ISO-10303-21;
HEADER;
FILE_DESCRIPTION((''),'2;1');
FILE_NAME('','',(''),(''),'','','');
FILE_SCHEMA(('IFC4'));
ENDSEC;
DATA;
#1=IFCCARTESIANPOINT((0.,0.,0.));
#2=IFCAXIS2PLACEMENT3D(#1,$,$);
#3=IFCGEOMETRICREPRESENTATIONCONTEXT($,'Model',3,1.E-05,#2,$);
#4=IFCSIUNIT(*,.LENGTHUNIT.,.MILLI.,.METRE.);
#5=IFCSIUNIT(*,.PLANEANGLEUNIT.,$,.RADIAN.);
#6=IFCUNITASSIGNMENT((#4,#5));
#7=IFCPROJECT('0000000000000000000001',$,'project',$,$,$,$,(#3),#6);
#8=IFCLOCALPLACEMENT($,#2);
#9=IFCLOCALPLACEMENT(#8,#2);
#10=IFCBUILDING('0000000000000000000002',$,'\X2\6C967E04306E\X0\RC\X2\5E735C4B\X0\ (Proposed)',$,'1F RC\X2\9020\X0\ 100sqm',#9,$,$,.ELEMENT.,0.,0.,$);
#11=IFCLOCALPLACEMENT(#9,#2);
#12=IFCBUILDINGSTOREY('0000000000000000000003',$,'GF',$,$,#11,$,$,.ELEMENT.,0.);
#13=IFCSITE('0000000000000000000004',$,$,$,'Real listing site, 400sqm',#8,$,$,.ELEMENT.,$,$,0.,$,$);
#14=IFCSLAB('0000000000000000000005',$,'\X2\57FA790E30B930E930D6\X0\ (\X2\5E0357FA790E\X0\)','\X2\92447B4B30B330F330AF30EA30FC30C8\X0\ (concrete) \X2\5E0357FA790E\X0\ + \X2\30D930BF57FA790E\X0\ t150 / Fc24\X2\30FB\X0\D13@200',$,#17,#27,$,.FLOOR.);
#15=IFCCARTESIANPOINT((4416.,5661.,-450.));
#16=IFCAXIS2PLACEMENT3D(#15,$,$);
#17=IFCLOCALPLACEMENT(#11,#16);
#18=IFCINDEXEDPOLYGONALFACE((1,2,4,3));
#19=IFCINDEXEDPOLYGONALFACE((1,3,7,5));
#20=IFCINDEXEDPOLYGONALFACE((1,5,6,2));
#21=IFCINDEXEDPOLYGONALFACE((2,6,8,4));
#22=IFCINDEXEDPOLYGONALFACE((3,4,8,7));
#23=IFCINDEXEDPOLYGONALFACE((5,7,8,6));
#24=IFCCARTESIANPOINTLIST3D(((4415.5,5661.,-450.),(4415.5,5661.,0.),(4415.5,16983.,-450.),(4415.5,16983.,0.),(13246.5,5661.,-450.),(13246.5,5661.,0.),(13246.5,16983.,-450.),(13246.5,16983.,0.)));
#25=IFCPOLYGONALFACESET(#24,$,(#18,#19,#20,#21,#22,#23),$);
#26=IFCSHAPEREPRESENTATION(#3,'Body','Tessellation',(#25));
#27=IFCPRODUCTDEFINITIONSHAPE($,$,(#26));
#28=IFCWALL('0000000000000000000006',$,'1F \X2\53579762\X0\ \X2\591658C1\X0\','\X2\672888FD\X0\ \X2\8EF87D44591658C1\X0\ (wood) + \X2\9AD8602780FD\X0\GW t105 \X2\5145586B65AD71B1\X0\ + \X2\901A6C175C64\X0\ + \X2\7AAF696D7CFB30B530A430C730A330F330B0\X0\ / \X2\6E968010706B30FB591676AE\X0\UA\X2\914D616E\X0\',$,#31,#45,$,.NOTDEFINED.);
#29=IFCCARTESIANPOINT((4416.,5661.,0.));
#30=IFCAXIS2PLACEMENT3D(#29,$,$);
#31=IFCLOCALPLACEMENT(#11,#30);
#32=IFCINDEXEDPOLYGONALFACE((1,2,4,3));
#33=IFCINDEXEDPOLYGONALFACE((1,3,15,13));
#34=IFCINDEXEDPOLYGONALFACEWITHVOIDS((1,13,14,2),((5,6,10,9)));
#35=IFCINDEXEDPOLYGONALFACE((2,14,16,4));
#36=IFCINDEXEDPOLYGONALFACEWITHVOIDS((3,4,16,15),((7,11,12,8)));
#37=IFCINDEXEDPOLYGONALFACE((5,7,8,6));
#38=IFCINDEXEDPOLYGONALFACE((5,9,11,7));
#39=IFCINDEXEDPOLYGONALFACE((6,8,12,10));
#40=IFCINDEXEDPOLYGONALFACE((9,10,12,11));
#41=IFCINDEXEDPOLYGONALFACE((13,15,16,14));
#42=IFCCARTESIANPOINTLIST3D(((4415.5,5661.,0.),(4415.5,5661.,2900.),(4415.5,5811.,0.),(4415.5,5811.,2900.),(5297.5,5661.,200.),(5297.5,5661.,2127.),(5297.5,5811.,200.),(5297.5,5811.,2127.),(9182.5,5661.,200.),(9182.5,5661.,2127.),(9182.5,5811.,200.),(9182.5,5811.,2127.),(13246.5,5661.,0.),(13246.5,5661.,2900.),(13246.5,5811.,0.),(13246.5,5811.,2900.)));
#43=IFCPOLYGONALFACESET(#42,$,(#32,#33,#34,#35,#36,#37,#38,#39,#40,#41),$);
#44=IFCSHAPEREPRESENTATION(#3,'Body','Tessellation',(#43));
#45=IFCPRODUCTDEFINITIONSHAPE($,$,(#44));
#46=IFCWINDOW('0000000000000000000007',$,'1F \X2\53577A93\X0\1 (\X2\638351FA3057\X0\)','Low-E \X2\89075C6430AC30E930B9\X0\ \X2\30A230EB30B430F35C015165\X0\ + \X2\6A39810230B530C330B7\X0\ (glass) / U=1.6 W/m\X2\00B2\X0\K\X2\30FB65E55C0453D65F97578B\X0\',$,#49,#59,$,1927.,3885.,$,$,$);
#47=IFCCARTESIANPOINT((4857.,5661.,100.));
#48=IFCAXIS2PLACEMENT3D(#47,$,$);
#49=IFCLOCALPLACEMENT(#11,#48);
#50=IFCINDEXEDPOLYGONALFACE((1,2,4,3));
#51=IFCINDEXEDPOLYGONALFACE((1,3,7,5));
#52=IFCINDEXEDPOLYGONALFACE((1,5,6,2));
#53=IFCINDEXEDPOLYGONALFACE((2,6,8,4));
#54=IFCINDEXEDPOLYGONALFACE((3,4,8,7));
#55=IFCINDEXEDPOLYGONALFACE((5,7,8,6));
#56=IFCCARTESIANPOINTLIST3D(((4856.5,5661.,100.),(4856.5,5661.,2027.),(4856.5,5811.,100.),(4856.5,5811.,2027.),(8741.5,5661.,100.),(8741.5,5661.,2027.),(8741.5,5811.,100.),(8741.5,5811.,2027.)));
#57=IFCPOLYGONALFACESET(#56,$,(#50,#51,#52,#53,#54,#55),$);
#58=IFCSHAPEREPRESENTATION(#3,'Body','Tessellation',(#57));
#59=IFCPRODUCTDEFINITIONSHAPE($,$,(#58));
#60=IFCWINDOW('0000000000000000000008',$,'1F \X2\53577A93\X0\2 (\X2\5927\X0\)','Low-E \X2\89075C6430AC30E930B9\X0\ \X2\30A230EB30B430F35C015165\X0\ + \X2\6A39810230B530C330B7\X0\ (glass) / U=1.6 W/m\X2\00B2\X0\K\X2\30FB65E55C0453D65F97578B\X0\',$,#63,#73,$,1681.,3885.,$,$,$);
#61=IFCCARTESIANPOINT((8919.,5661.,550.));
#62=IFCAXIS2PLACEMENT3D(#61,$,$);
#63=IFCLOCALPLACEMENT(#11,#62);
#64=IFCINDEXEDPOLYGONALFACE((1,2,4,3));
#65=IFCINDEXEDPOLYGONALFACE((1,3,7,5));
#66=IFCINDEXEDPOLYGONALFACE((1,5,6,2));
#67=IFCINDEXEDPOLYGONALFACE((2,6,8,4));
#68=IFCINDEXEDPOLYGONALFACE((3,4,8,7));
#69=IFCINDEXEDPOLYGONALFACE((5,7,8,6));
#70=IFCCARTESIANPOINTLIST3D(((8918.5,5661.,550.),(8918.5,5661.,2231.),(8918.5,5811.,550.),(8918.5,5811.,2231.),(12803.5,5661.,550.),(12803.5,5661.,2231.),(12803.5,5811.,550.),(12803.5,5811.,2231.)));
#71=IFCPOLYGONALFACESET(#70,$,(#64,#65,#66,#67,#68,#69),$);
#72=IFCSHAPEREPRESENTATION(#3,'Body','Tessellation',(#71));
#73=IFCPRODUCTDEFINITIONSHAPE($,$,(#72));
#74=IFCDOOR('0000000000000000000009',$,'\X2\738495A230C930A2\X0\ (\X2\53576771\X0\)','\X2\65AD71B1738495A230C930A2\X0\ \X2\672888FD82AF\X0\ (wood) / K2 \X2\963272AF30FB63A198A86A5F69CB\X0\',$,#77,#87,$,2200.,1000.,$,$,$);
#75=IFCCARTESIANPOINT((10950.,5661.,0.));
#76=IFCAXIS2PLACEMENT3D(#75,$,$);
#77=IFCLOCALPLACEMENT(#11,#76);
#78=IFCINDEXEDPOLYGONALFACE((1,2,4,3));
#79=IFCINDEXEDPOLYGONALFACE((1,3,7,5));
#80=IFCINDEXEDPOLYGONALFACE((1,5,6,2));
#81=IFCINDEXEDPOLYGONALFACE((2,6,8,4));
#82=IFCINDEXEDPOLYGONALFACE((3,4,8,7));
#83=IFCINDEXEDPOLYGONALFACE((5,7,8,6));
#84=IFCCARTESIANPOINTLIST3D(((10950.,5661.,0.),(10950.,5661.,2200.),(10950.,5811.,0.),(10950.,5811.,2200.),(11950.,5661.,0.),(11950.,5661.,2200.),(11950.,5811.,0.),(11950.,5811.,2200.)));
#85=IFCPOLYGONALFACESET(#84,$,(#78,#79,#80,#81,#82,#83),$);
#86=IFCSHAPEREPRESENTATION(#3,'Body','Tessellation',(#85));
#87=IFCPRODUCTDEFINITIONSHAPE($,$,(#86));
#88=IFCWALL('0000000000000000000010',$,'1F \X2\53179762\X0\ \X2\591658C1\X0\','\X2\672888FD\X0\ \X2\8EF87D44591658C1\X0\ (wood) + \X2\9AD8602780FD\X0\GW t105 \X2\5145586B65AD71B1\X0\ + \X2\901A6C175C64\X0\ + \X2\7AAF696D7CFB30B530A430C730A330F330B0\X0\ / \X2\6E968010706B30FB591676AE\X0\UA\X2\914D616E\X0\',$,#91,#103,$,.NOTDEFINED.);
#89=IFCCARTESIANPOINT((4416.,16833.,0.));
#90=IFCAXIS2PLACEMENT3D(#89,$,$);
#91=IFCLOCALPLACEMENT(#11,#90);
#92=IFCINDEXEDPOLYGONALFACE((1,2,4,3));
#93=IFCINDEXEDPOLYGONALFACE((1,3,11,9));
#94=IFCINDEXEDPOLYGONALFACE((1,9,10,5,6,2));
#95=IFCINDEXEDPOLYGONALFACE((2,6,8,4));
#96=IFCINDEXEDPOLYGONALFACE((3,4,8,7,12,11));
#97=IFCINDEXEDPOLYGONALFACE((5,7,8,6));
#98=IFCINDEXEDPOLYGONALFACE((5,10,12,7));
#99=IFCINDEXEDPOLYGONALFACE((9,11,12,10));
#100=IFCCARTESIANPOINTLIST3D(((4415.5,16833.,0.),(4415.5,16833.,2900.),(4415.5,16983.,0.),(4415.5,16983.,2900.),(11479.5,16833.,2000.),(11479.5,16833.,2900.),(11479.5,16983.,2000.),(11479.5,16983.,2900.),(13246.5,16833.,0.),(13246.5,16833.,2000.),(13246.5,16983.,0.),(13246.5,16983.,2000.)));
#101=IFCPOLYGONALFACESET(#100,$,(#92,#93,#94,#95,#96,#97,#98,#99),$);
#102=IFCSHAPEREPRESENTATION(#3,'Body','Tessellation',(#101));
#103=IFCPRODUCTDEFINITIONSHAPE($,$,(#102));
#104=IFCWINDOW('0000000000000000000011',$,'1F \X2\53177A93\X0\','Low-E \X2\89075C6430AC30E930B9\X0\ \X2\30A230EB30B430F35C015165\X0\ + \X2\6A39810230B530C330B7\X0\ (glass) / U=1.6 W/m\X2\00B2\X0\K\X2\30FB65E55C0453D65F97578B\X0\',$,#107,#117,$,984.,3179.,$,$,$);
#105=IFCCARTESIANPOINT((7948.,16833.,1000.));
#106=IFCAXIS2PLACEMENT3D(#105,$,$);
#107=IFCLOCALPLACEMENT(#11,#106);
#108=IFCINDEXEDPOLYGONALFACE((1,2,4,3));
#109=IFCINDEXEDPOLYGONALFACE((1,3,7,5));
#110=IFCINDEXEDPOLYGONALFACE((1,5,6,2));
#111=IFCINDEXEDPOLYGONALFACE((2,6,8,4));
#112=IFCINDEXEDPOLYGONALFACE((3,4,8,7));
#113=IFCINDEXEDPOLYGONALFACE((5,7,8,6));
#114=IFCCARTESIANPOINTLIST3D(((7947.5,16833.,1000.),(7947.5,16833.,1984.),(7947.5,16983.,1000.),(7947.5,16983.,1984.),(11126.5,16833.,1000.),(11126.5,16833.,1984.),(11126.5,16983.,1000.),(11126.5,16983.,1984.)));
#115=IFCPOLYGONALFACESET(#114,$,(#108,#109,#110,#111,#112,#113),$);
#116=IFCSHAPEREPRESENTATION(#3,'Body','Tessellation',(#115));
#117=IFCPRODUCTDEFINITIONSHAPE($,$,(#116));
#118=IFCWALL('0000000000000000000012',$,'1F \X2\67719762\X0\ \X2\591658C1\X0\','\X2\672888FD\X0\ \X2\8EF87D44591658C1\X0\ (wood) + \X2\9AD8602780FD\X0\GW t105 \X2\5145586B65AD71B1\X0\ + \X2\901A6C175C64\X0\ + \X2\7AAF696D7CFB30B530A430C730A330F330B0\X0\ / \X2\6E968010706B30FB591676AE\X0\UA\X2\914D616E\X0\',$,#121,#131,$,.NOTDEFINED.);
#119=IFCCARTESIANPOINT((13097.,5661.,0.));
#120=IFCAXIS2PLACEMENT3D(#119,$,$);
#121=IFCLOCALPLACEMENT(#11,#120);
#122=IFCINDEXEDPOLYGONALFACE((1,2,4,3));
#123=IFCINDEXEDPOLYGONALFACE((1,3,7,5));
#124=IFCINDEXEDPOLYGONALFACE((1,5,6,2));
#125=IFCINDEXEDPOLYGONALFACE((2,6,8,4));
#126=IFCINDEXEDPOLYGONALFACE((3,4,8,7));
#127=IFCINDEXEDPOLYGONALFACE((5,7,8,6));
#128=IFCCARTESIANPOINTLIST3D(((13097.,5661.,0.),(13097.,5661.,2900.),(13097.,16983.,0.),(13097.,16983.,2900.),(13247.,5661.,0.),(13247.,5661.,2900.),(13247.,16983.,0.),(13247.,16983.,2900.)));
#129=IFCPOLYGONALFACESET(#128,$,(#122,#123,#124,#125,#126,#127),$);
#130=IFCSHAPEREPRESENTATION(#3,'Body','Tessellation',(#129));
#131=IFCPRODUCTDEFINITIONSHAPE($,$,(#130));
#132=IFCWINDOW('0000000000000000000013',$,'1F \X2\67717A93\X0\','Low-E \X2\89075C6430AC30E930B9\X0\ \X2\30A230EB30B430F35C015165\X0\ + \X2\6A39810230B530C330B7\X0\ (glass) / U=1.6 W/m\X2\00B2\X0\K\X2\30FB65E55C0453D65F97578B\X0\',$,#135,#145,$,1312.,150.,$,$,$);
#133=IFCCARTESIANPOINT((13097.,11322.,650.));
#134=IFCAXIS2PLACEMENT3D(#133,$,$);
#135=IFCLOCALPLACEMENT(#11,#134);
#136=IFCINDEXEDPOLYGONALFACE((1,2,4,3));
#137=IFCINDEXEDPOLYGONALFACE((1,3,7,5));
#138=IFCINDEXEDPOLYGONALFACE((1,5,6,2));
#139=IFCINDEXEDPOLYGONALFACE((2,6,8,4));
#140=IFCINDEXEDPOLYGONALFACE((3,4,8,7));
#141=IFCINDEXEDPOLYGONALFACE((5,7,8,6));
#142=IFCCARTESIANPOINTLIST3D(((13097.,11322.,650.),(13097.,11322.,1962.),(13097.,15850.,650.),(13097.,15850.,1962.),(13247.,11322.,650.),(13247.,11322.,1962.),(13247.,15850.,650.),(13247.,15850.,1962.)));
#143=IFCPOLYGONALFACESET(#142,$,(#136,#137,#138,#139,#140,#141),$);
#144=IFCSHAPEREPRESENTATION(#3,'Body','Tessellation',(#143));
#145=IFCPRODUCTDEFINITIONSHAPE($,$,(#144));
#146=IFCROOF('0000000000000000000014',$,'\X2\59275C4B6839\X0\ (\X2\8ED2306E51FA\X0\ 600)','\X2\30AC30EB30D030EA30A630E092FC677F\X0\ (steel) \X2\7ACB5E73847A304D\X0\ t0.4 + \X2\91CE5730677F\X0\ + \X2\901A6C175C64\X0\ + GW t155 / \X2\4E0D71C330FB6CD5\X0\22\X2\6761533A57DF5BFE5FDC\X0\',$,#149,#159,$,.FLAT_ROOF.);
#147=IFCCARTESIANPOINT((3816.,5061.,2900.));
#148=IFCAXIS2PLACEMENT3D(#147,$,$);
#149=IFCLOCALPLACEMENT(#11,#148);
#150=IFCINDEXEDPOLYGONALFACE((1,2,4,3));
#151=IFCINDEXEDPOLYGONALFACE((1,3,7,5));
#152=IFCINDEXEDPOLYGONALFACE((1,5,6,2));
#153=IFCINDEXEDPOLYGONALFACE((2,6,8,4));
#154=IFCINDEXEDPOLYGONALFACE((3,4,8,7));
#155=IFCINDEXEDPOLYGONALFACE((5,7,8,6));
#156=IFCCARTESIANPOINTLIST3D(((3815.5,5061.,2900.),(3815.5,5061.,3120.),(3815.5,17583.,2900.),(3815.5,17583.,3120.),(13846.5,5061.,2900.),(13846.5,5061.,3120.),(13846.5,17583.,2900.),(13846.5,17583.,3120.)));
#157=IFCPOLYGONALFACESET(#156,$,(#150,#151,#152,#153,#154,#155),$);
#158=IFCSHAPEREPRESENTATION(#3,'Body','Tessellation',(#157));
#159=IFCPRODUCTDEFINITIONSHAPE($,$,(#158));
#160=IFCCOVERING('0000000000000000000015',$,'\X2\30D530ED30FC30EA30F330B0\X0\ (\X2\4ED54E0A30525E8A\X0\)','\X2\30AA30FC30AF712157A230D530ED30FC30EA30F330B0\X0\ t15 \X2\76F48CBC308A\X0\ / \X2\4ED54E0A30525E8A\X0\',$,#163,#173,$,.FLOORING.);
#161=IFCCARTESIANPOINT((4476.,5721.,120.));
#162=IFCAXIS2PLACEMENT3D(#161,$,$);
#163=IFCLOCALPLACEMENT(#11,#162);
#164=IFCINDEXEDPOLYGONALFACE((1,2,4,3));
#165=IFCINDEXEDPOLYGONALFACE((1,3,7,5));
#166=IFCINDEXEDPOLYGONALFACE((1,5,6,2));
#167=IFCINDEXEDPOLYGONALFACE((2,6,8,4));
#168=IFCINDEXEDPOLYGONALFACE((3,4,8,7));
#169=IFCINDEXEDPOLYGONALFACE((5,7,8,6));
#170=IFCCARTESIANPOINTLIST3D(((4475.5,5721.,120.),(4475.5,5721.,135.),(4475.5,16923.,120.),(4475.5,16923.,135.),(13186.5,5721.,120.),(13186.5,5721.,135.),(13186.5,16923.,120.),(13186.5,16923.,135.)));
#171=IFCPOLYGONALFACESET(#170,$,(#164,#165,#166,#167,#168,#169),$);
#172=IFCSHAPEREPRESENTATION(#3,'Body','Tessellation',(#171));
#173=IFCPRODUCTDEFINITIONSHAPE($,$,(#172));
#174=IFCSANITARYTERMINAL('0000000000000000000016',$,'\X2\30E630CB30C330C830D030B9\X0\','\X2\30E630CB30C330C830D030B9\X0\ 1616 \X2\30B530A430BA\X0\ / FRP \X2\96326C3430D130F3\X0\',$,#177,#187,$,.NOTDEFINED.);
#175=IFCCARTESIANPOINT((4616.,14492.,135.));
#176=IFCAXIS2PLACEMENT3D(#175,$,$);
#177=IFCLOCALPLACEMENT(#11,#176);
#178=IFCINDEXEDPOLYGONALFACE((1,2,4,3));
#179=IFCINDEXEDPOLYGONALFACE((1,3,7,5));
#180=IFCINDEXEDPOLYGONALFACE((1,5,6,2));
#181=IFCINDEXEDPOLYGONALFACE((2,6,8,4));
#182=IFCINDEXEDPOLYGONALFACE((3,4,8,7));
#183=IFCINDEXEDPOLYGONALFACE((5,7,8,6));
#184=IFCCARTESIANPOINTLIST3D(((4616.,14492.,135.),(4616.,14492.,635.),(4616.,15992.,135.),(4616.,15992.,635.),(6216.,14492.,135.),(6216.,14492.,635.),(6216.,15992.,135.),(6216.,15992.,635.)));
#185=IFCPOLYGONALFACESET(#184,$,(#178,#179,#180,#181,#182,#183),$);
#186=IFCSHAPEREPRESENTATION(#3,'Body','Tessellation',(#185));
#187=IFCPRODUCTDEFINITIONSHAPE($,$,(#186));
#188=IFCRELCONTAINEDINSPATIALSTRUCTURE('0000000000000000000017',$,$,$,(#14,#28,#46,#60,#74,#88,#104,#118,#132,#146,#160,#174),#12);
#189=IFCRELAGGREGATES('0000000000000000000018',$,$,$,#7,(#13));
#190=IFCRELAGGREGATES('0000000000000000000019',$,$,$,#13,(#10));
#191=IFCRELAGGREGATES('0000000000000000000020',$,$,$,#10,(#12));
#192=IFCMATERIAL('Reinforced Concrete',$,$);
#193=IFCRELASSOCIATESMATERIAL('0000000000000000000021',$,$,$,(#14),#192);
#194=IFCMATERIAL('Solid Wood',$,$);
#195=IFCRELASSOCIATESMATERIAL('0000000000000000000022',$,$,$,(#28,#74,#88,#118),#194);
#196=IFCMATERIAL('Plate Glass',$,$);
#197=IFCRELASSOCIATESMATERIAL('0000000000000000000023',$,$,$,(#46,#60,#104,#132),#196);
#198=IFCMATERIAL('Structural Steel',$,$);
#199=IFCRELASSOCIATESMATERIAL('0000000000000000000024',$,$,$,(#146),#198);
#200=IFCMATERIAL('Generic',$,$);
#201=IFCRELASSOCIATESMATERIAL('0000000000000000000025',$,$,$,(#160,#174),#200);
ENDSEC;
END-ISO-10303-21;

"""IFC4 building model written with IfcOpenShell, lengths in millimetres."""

from ifc_helpers import new_model, si_unit, frame, frame_2d, origin, place, context, project, spatial, rectangle, extrude, material, element, fill, save


model = new_model("IFC4")

# Units and contexts
model_context = context("Model", 3, precision=1e-05, world=origin())
ifc_project = project(units=[si_unit("LENGTHUNIT", "METRE", prefix="MILLI"), si_unit("PLANEANGLEUNIT", "RADIAN")], contexts=[model_context])

# Site, building, storey
site_placement = place(None, origin())
site = spatial("IfcSite", under=ifc_project, at=site_placement, ObjectType="Real listing site, 400sqm", CompositionType="ELEMENT", RefElevation=0.0)
building_placement = place(site_placement, origin())
building = spatial("IfcBuilding", under=site, at=building_placement, Name="沖縄のRC平屋 (Proposed)", ObjectType="1F RC造 100sqm", CompositionType="ELEMENT", ElevationOfRefHeight=0.0, ElevationOfTerrain=0.0)
storey_placement = place(building_placement, origin())
storey = spatial("IfcBuildingStorey", under=building, at=storey_placement, Name="GF", CompositionType="ELEMENT", Elevation=0.0)

# Slab
ifc_material_1 = material(Name="Reinforced Concrete")
slab_1_placement = place(storey_placement, frame((4416.0, 5661.0, -450.0)))
element("IfcSlab", 1, at=slab_1_placement, inside=storey, material=ifc_material_1, Name="基礎スラブ (布基礎)", Description="鉄筋コンクリート (concrete) 布基礎 + ベタ基礎 t150 / Fc24・D13@200", PredefinedType="FLOOR", context=model_context, shape_type="SweptSolid", body=[
    extrude(rectangle(XDim=8831.0, YDim=11322.0, at=frame_2d((4415.0, 5661.0))), frame((4416.0, 5661.0, -450.0)), (0.0, 0.0, 1.0), 450.0),
])
ifc_material_2 = material(Name="Solid Wood")

# Wall, openings, windows, door
wall_1_placement = place(storey_placement, frame((4416.0, 5661.0, 0.0)))
wall_1 = element("IfcWall", 2, at=wall_1_placement, inside=storey, material=ifc_material_2, Name="1F 南面 外壁", Description="木製 軸組外壁 (wood) + 高性能GW t105 充填断熱 + 通気層 + 窯業系サイディング / 準耐火・外皮UA配慮", PredefinedType="NOTDEFINED", context=model_context, shape_type="SweptSolid", body=[
    extrude(rectangle(XDim=8831.0, YDim=150.0, at=frame_2d((4415.0, 75.0))), frame((4416.0, 5661.0, 0.0)), (0.0, 0.0, 1.0), 2900.0),
])
opening_1_placement = place(storey_placement, frame((4857.0, 5661.0, 100.0)))
opening_1 = element("IfcOpeningElement", 3, at=opening_1_placement, cuts=wall_1, PredefinedType="NOTDEFINED", context=model_context, shape_type="SweptSolid", body=[
    extrude(rectangle(XDim=3885.0, YDim=150.0, at=frame_2d((1942.0, 75.0))), frame((4857.0, 5661.0, 100.0)), (0.0, 0.0, 1.0), 1927.0),
])
opening_2_placement = place(storey_placement, frame((8919.0, 5661.0, 550.0)))
opening_2 = element("IfcOpeningElement", 4, at=opening_2_placement, cuts=wall_1, PredefinedType="NOTDEFINED", context=model_context, shape_type="SweptSolid", body=[
    extrude(rectangle(XDim=3885.0, YDim=150.0, at=frame_2d((1942.0, 75.0))), frame((8919.0, 5661.0, 550.0)), (0.0, 0.0, 1.0), 1681.0),
])
opening_3_placement = place(storey_placement, frame((10950.0, 5661.0, 0.0)))
opening_3 = element("IfcOpeningElement", 5, at=opening_3_placement, cuts=wall_1, PredefinedType="NOTDEFINED", context=model_context, shape_type="SweptSolid", body=[
    extrude(rectangle(XDim=1000.0, YDim=150.0, at=frame_2d((500.0, 75.0))), frame((10950.0, 5661.0, 0.0)), (0.0, 0.0, 1.0), 2200.0),
])
ifc_material_3 = material(Name="Plate Glass")
window_1_placement = place(storey_placement, frame((4857.0, 5661.0, 100.0)))
window_1 = element("IfcWindow", 6, at=window_1_placement, inside=storey, material=ifc_material_3, Name="1F 南窓1 (掃出し)", Description="Low-E 複層ガラス アルゴン封入 + 樹脂サッシ (glass) / U=1.6 W/m²K・日射取得型", OverallHeight=1927.0, OverallWidth=3885.0, context=model_context, shape_type="SweptSolid", body=[
    extrude(rectangle(XDim=3885.0, YDim=150.0, at=frame_2d((1942.0, 75.0))), frame((4857.0, 5661.0, 100.0)), (0.0, 0.0, 1.0), 1927.0),
])
fill(opening_1, window_1)
window_2_placement = place(storey_placement, frame((8919.0, 5661.0, 550.0)))
window_2 = element("IfcWindow", 7, at=window_2_placement, inside=storey, material=ifc_material_3, Name="1F 南窓2 (大)", Description="Low-E 複層ガラス アルゴン封入 + 樹脂サッシ (glass) / U=1.6 W/m²K・日射取得型", OverallHeight=1681.0, OverallWidth=3885.0, context=model_context, shape_type="SweptSolid", body=[
    extrude(rectangle(XDim=3885.0, YDim=150.0, at=frame_2d((1942.0, 75.0))), frame((8919.0, 5661.0, 550.0)), (0.0, 0.0, 1.0), 1681.0),
])
fill(opening_2, window_2)
door_placement = place(storey_placement, frame((10950.0, 5661.0, 0.0)))
door = element("IfcDoor", 8, at=door_placement, inside=storey, material=ifc_material_2, Name="玄関ドア (南東)", Description="断熱玄関ドア 木製芯 (wood) / K2 防犯・採風機構", OverallHeight=2200.0, OverallWidth=1000.0, context=model_context, shape_type="SweptSolid", body=[
    extrude(rectangle(XDim=1000.0, YDim=150.0, at=frame_2d((500.0, 75.0))), frame((10950.0, 5661.0, 0.0)), (0.0, 0.0, 1.0), 2200.0),
])
fill(opening_3, door)

# Walls, openings, windows
wall_2_placement = place(storey_placement, frame((4416.0, 16833.0, 0.0)))
wall_2 = element("IfcWall", 9, at=wall_2_placement, inside=storey, material=ifc_material_2, Name="1F 北面 外壁", Description="木製 軸組外壁 (wood) + 高性能GW t105 充填断熱 + 通気層 + 窯業系サイディング / 準耐火・外皮UA配慮", PredefinedType="NOTDEFINED", context=model_context, shape_type="SweptSolid", body=[
    extrude(rectangle(XDim=8831.0, YDim=150.0, at=frame_2d((4415.0, 75.0))), frame((4416.0, 16833.0, 0.0)), (0.0, 0.0, 1.0), 2900.0),
])
opening_4_placement = place(storey_placement, frame((7948.0, 16833.0, 1000.0)))
opening_4 = element("IfcOpeningElement", 10, at=opening_4_placement, cuts=wall_2, PredefinedType="NOTDEFINED", context=model_context, shape_type="SweptSolid", body=[
    extrude(rectangle(XDim=3179.0, YDim=150.0, at=frame_2d((1589.0, 75.0))), frame((7948.0, 16833.0, 1000.0)), (0.0, 0.0, 1.0), 984.0),
])
window_3_placement = place(storey_placement, frame((7948.0, 16833.0, 1000.0)))
window_3 = element("IfcWindow", 11, at=window_3_placement, inside=storey, material=ifc_material_3, Name="1F 北窓", Description="Low-E 複層ガラス アルゴン封入 + 樹脂サッシ (glass) / U=1.6 W/m²K・日射取得型", OverallHeight=984.0, OverallWidth=3179.0, context=model_context, shape_type="SweptSolid", body=[
    extrude(rectangle(XDim=3179.0, YDim=150.0, at=frame_2d((1589.0, 75.0))), frame((7948.0, 16833.0, 1000.0)), (0.0, 0.0, 1.0), 984.0),
])
fill(opening_4, window_3)
wall_3_placement = place(storey_placement, frame((13097.0, 5661.0, 0.0)))
wall_3 = element("IfcWall", 12, at=wall_3_placement, inside=storey, material=ifc_material_2, Name="1F 東面 外壁", Description="木製 軸組外壁 (wood) + 高性能GW t105 充填断熱 + 通気層 + 窯業系サイディング / 準耐火・外皮UA配慮", PredefinedType="NOTDEFINED", context=model_context, shape_type="SweptSolid", body=[
    extrude(rectangle(XDim=150.0, YDim=11322.0, at=frame_2d((75.0, 5661.0))), frame((13097.0, 5661.0, 0.0)), (0.0, 0.0, 1.0), 2900.0),
])
opening_5_placement = place(storey_placement, frame((13097.0, 11322.0, 650.0)))
opening_5 = element("IfcOpeningElement", 13, at=opening_5_placement, cuts=wall_3, PredefinedType="NOTDEFINED", context=model_context, shape_type="SweptSolid", body=[
    extrude(rectangle(XDim=150.0, YDim=4528.0, at=frame_2d((75.0, 2264.0))), frame((13097.0, 11322.0, 650.0)), (0.0, 0.0, 1.0), 1312.0),
])
window_4_placement = place(storey_placement, frame((13097.0, 11322.0, 650.0)))
window_4 = element("IfcWindow", 14, at=window_4_placement, inside=storey, material=ifc_material_3, Name="1F 東窓", Description="Low-E 複層ガラス アルゴン封入 + 樹脂サッシ (glass) / U=1.6 W/m²K・日射取得型", OverallHeight=1312.0, OverallWidth=150.0, context=model_context, shape_type="SweptSolid", body=[
    extrude(rectangle(XDim=150.0, YDim=4528.0, at=frame_2d((75.0, 2264.0))), frame((13097.0, 11322.0, 650.0)), (0.0, 0.0, 1.0), 1312.0),
])
fill(opening_5, window_4)

# Roof
ifc_material_4 = material(Name="Structural Steel")
roof_placement = place(storey_placement, frame((3816.0, 5061.0, 2900.0)))
element("IfcRoof", 15, at=roof_placement, inside=storey, material=ifc_material_4, Name="大屋根 (軒の出 600)", Description="ガルバリウム鋼板 (steel) 立平葺き t0.4 + 野地板 + 通気層 + GW t155 / 不燃・法22条区域対応", PredefinedType="FLAT_ROOF", context=model_context, shape_type="SweptSolid", body=[
    extrude(rectangle(XDim=10031.0, YDim=12522.0, at=frame_2d((5015.0, 6261.0))), frame((3816.0, 5061.0, 2900.0)), (0.0, 0.0, 1.0), 220.0),
])

# Covering
ifc_material_5 = material(Name="Generic")
covering_placement = place(storey_placement, frame((4476.0, 5721.0, 120.0)))
element("IfcCovering", 16, at=covering_placement, inside=storey, material=ifc_material_5, Name="フローリング (仕上げ床)", Description="オーク無垢フローリング t15 直貼り / 仕上げ床", PredefinedType="FLOORING", context=model_context, shape_type="SweptSolid", body=[
    extrude(rectangle(XDim=8711.0, YDim=11202.0, at=frame_2d((4355.0, 5601.0))), frame((4476.0, 5721.0, 120.0)), (0.0, 0.0, 1.0), 15.0),
])

# Sanitary terminal
sanitary_terminal_1_placement = place(storey_placement, frame((4616.0, 14492.0, 135.0)))
element("IfcSanitaryTerminal", 17, at=sanitary_terminal_1_placement, inside=storey, material=ifc_material_5, Name="ユニットバス", Description="ユニットバス 1616 サイズ / FRP 防水パン", PredefinedType="NOTDEFINED", context=model_context, shape_type="SweptSolid", body=[
    extrude(rectangle(XDim=1600.0, YDim=1500.0, at=frame_2d((800.0, 750.0))), frame((4616.0, 14492.0, 135.0)), (0.0, 0.0, 1.0), 500.0),
])

save(model, "model.ifc")
